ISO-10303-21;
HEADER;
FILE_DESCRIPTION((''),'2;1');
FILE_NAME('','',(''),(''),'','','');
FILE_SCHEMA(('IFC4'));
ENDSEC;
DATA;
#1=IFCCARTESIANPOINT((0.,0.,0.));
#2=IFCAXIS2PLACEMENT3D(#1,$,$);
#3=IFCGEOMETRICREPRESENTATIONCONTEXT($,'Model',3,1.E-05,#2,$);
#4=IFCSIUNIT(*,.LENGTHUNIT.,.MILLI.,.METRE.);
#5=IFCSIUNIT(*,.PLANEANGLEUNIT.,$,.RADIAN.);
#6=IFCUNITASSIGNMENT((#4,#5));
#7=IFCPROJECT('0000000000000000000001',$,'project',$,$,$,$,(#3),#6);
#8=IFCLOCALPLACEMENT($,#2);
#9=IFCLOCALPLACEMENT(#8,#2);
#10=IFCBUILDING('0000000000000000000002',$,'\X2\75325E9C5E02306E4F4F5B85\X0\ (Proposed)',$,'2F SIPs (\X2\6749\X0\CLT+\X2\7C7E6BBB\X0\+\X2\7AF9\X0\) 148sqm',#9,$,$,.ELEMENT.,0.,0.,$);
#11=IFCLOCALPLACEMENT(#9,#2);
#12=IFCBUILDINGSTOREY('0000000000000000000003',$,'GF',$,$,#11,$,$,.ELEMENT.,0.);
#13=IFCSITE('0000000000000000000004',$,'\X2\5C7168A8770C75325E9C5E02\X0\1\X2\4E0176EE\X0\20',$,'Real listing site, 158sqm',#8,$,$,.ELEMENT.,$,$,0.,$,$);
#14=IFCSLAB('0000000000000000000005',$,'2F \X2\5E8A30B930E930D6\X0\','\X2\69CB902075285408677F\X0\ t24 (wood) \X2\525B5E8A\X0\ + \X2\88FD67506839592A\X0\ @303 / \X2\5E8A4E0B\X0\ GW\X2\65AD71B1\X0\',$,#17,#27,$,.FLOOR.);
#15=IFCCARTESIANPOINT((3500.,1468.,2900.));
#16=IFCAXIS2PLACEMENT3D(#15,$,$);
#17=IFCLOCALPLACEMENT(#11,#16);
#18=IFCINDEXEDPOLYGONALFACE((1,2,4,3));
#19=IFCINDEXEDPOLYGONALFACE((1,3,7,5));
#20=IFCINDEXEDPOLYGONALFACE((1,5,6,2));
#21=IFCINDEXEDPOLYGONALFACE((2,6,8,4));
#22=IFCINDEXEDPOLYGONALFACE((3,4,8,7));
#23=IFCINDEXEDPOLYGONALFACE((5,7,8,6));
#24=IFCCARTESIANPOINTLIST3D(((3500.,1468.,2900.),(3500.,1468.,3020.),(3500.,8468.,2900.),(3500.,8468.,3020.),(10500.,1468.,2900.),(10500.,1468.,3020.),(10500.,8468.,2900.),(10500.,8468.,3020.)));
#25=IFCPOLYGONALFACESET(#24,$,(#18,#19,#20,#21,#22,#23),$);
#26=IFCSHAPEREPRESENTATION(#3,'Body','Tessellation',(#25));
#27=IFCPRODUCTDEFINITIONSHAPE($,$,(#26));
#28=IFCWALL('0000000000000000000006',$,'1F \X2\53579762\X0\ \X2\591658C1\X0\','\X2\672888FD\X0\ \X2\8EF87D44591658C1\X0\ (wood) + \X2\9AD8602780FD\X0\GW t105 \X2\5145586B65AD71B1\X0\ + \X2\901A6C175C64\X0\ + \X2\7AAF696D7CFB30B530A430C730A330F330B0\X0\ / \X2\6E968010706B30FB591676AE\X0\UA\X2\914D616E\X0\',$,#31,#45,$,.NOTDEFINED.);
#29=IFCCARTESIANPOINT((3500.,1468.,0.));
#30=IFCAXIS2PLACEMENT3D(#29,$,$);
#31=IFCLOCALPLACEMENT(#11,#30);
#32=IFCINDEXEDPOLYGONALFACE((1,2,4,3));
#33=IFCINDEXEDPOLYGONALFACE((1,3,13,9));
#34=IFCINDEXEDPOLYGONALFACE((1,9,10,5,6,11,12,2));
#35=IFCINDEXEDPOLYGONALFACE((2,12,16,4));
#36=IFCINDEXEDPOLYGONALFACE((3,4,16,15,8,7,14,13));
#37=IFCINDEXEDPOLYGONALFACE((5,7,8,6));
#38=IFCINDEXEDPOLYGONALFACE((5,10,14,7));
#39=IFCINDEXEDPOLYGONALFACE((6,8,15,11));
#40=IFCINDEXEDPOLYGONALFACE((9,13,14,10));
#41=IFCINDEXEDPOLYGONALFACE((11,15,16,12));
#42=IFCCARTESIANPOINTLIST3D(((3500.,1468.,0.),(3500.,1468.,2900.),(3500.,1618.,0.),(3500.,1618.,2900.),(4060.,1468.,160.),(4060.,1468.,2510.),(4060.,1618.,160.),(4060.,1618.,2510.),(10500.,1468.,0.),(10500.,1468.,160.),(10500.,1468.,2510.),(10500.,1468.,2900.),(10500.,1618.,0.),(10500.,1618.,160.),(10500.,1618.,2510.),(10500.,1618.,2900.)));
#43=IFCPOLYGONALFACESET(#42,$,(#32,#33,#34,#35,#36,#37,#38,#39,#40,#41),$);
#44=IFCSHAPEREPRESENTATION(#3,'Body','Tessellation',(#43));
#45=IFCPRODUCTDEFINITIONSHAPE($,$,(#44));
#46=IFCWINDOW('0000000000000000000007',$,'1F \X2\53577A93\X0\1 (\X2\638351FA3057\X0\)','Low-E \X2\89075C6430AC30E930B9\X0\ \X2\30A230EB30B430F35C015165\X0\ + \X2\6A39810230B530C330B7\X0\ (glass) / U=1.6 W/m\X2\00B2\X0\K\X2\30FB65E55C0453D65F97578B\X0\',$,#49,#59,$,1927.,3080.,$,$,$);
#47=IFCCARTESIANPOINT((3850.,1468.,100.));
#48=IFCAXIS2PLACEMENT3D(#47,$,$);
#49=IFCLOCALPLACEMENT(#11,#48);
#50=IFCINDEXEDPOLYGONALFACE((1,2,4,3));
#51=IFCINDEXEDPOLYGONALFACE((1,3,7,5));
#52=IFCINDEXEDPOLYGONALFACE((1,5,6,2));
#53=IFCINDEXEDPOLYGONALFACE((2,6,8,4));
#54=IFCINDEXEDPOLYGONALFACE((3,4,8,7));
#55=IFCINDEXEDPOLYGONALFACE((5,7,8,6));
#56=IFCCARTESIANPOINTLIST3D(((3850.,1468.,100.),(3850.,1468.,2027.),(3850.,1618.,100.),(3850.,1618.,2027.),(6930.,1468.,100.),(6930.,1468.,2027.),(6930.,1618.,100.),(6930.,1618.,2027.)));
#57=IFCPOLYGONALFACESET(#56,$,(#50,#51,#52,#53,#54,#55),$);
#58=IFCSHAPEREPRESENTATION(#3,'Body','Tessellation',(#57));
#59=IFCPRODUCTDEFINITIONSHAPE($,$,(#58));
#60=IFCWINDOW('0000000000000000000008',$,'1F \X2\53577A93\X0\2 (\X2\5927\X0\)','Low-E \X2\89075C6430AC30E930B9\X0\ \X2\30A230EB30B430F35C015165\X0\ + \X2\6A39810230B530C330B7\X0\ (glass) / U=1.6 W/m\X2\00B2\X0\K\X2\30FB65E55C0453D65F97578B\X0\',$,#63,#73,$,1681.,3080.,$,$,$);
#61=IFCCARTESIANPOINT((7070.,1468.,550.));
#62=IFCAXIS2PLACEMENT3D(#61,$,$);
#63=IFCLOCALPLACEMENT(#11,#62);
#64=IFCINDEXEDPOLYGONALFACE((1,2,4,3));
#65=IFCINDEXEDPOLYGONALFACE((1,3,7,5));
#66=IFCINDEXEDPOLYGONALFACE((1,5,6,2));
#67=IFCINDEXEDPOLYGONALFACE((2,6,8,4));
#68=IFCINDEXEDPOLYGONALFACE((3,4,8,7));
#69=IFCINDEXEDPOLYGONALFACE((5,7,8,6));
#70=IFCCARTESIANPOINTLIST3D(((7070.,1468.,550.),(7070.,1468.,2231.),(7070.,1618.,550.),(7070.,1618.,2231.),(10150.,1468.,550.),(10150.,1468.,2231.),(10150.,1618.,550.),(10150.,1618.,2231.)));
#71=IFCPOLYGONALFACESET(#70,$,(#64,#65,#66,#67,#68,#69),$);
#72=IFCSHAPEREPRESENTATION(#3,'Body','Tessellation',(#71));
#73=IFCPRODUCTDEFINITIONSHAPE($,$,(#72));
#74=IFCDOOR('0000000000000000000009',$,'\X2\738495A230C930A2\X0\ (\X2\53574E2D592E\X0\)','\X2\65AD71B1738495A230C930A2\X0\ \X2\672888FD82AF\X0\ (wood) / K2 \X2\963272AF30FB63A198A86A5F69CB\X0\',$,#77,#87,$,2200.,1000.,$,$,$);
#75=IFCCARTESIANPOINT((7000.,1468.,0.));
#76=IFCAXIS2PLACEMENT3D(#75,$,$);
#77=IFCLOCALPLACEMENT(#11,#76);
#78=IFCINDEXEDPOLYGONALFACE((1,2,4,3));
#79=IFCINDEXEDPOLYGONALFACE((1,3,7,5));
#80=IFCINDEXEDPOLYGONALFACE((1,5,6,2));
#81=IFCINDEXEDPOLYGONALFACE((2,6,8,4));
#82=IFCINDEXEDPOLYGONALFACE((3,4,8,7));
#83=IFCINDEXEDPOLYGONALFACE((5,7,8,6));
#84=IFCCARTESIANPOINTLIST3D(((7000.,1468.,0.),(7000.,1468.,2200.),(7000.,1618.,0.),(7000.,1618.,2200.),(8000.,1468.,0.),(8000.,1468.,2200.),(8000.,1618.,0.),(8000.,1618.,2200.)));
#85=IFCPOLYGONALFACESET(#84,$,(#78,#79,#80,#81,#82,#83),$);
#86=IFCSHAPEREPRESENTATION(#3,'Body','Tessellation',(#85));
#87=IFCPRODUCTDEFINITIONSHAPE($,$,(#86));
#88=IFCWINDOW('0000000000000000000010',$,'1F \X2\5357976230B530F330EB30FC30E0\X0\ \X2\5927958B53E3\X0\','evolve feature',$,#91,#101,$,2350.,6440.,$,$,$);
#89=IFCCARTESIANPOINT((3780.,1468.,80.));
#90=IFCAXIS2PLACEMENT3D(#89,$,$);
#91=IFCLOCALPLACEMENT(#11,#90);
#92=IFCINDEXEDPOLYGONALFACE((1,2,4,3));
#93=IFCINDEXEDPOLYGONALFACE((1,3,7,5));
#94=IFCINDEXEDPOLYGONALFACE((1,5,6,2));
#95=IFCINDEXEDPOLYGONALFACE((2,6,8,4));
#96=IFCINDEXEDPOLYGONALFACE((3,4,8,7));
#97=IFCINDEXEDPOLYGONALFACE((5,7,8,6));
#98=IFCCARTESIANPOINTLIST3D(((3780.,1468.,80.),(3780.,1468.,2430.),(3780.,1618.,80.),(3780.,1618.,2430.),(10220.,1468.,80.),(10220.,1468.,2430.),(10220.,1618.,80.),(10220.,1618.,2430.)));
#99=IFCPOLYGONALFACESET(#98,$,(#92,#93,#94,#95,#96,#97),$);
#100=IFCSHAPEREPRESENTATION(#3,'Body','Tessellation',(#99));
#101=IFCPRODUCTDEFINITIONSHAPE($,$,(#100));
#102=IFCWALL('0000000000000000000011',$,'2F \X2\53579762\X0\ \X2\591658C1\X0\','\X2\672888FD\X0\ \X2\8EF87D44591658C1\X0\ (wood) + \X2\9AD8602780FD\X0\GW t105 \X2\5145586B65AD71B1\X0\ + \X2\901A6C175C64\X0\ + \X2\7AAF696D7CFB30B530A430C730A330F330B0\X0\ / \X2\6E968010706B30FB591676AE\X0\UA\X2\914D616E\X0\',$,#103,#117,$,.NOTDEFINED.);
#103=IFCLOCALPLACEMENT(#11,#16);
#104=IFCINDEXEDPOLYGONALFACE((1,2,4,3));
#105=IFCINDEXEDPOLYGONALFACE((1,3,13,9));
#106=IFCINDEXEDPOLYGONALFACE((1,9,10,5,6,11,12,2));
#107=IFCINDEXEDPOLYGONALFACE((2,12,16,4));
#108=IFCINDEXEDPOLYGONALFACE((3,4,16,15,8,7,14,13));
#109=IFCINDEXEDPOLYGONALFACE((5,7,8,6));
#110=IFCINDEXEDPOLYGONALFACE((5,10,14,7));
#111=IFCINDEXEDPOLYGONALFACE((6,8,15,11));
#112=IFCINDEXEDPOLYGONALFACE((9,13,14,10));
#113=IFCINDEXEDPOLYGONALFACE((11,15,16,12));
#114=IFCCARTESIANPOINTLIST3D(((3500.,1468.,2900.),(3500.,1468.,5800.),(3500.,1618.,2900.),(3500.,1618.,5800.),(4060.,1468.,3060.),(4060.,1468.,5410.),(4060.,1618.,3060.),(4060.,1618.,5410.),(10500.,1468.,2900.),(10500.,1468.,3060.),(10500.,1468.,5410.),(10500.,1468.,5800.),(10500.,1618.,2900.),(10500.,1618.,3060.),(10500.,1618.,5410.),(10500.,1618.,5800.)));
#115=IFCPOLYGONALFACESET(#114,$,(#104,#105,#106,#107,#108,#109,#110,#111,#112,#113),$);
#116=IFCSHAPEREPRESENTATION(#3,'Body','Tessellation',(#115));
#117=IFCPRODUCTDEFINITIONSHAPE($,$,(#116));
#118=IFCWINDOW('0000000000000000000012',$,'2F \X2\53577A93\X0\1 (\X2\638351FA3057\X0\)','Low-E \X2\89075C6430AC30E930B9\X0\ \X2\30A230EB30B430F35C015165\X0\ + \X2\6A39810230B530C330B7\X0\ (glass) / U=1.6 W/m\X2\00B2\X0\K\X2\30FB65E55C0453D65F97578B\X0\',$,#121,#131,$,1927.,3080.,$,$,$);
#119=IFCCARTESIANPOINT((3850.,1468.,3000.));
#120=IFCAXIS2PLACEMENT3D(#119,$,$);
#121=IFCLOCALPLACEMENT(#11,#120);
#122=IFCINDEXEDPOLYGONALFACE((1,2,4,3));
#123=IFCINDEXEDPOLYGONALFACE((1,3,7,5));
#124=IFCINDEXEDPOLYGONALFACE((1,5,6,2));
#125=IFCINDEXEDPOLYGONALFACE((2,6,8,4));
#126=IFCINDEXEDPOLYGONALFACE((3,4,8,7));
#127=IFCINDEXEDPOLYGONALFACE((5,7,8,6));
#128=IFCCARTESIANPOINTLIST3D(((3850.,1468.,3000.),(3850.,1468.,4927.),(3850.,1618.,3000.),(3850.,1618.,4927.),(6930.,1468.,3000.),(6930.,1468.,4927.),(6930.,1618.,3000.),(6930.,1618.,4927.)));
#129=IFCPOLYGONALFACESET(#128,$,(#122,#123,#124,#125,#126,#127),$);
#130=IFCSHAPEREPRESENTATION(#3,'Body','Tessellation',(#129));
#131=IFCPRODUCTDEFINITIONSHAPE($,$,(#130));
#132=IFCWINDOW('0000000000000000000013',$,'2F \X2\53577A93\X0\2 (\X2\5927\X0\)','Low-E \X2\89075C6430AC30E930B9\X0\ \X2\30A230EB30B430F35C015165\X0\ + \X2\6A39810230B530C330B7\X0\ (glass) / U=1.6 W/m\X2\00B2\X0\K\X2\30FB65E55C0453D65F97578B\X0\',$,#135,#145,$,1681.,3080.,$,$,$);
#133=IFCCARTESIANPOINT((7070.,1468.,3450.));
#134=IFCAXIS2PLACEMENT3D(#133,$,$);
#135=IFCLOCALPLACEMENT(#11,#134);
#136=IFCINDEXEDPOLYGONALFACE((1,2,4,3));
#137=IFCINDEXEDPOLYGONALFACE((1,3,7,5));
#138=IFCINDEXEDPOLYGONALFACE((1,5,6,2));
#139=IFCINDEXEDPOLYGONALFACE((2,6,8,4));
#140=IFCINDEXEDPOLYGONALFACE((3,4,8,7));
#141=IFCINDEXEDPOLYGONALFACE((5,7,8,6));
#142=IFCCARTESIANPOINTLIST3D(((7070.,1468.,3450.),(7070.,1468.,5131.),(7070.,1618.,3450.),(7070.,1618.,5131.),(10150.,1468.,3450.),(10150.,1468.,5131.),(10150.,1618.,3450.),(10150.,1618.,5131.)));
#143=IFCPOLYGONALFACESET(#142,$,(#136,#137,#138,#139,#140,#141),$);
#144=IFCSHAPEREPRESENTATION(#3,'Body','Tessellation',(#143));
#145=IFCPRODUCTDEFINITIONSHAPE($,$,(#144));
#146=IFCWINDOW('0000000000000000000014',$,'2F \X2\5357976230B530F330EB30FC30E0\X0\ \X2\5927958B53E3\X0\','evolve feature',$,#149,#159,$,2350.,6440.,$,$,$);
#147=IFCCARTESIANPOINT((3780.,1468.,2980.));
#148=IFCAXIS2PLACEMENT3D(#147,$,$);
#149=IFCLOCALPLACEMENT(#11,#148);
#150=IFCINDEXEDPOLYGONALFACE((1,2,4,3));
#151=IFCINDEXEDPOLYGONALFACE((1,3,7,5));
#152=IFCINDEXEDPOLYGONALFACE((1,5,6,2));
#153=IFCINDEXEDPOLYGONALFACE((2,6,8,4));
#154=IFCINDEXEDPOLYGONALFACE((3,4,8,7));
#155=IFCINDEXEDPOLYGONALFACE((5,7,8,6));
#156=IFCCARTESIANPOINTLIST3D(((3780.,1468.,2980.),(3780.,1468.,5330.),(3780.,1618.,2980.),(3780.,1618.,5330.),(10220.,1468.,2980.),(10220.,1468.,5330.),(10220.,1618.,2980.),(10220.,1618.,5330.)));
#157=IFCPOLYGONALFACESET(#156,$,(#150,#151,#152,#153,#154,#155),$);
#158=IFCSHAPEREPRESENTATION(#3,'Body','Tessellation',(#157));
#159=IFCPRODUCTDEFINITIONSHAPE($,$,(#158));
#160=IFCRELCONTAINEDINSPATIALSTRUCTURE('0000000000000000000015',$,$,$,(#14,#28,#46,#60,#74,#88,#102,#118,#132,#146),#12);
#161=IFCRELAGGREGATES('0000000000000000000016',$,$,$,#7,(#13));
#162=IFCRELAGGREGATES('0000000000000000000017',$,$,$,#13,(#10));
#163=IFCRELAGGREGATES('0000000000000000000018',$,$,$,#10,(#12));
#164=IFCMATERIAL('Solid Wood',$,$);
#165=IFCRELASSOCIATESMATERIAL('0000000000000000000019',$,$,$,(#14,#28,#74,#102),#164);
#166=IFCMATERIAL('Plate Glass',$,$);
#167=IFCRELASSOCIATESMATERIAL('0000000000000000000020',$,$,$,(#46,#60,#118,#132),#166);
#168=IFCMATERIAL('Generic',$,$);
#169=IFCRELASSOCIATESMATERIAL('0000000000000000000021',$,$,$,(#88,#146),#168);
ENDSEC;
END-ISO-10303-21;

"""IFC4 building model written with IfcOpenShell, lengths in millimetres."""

from ifc_helpers import new_model, si_unit, frame, frame_2d, origin, place, context, project, spatial, rectangle, extrude, material, element, fill, save


model = new_model("IFC4")

# Units and contexts
model_context = context("Model", 3, precision=1e-05, world=origin())
ifc_project = project(units=[si_unit("LENGTHUNIT", "METRE", prefix="MILLI"), si_unit("PLANEANGLEUNIT", "RADIAN")], contexts=[model_context])

# Site, building, storey
site_placement = place(None, origin())
site = spatial("IfcSite", under=ifc_project, at=site_placement, Name="山梨県甲府市1丁目20", ObjectType="Real listing site, 158sqm", CompositionType="ELEMENT", RefElevation=0.0)
building_placement = place(site_placement, origin())
building = spatial("IfcBuilding", under=site, at=building_placement, Name="甲府市の住宅 (Proposed)", ObjectType="2F SIPs (杉CLT+籾殻+竹) 148sqm", CompositionType="ELEMENT", ElevationOfRefHeight=0.0, ElevationOfTerrain=0.0)
storey_placement = place(building_placement, origin())
storey = spatial("IfcBuildingStorey", under=building, at=storey_placement, Name="GF", CompositionType="ELEMENT", Elevation=0.0)

# Slab
ifc_material_1 = material(Name="Solid Wood")
slab_1_placement = place(storey_placement, frame((3500.0, 1468.0, 2900.0)))
element("IfcSlab", 1, at=slab_1_placement, inside=storey, material=ifc_material_1, Name="2F 床スラブ", Description="構造用合板 t24 (wood) 剛床 + 製材根太 @303 / 床下 GW断熱", PredefinedType="FLOOR", context=model_context, shape_type="SweptSolid", body=[
    extrude(rectangle(XDim=7000.0, YDim=7000.0, at=frame_2d((3500.0, 3500.0))), frame((3500.0, 1468.0, 2900.0)), (0.0, 0.0, 1.0), 120.0),
])
ifc_material_2 = material(Name="Generic")

# Wall, openings, windows, door
wall_1_placement = place(storey_placement, frame((3500.0, 1468.0, 0.0)))
wall_1 = element("IfcWall", 2, at=wall_1_placement, inside=storey, material=ifc_material_1, Name="1F 南面 外壁", Description="木製 軸組外壁 (wood) + 高性能GW t105 充填断熱 + 通気層 + 窯業系サイディング / 準耐火・外皮UA配慮", PredefinedType="NOTDEFINED", context=model_context, shape_type="SweptSolid", body=[
    extrude(rectangle(XDim=7000.0, YDim=150.0, at=frame_2d((3500.0, 75.0))), frame((3500.0, 1468.0, 0.0)), (0.0, 0.0, 1.0), 2900.0),
])
opening_1_placement = place(storey_placement, frame((3850.0, 1468.0, 100.0)))
opening_1 = element("IfcOpeningElement", 3, at=opening_1_placement, cuts=wall_1, PredefinedType="NOTDEFINED", context=model_context, shape_type="SweptSolid", body=[
    extrude(rectangle(XDim=3080.0, YDim=150.0, at=frame_2d((1540.0, 75.0))), frame((3850.0, 1468.0, 100.0)), (0.0, 0.0, 1.0), 1927.0),
])
opening_2_placement = place(storey_placement, frame((7070.0, 1468.0, 550.0)))
opening_2 = element("IfcOpeningElement", 4, at=opening_2_placement, cuts=wall_1, PredefinedType="NOTDEFINED", context=model_context, shape_type="SweptSolid", body=[
    extrude(rectangle(XDim=3080.0, YDim=150.0, at=frame_2d((1540.0, 75.0))), frame((7070.0, 1468.0, 550.0)), (0.0, 0.0, 1.0), 1681.0),
])
opening_3_placement = place(storey_placement, frame((7000.0, 1468.0, 0.0)))
opening_3 = element("IfcOpeningElement", 5, at=opening_3_placement, cuts=wall_1, PredefinedType="NOTDEFINED", context=model_context, shape_type="SweptSolid", body=[
    extrude(rectangle(XDim=1000.0, YDim=150.0, at=frame_2d((500.0, 75.0))), frame((7000.0, 1468.0, 0.0)), (0.0, 0.0, 1.0), 2200.0),
])
opening_4_placement = place(storey_placement, frame((3780.0, 1468.0, 80.0)))
opening_4 = element("IfcOpeningElement", 6, at=opening_4_placement, cuts=wall_1, PredefinedType="NOTDEFINED", context=model_context, shape_type="SweptSolid", body=[
    extrude(rectangle(XDim=6440.0, YDim=150.0, at=frame_2d((3220.0, 75.0))), frame((3780.0, 1468.0, 80.0)), (0.0, 0.0, 1.0), 2350.0),
])
ifc_material_3 = material(Name="Plate Glass")
window_1_placement = place(storey_placement, frame((3850.0, 1468.0, 100.0)))
window_1 = element("IfcWindow", 7, at=window_1_placement, inside=storey, material=ifc_material_3, Name="1F 南窓1 (掃出し)", Description="Low-E 複層ガラス アルゴン封入 + 樹脂サッシ (glass) / U=1.6 W/m²K・日射取得型", OverallHeight=1927.0, OverallWidth=3080.0, context=model_context, shape_type="SweptSolid", body=[
    extrude(rectangle(XDim=3080.0, YDim=150.0, at=frame_2d((1540.0, 75.0))), frame((3850.0, 1468.0, 100.0)), (0.0, 0.0, 1.0), 1927.0),
])
fill(opening_1, window_1)
window_2_placement = place(storey_placement, frame((7070.0, 1468.0, 550.0)))
window_2 = element("IfcWindow", 8, at=window_2_placement, inside=storey, material=ifc_material_3, Name="1F 南窓2 (大)", Description="Low-E 複層ガラス アルゴン封入 + 樹脂サッシ (glass) / U=1.6 W/m²K・日射取得型", OverallHeight=1681.0, OverallWidth=3080.0, context=model_context, shape_type="SweptSolid", body=[
    extrude(rectangle(XDim=3080.0, YDim=150.0, at=frame_2d((1540.0, 75.0))), frame((7070.0, 1468.0, 550.0)), (0.0, 0.0, 1.0), 1681.0),
])
fill(opening_2, window_2)
door_placement = place(storey_placement, frame((7000.0, 1468.0, 0.0)))
door = element("IfcDoor", 9, at=door_placement, inside=storey, material=ifc_material_1, Name="玄関ドア (南中央)", Description="断熱玄関ドア 木製芯 (wood) / K2 防犯・採風機構", OverallHeight=2200.0, OverallWidth=1000.0, context=model_context, shape_type="SweptSolid", body=[
    extrude(rectangle(XDim=1000.0, YDim=150.0, at=frame_2d((500.0, 75.0))), frame((7000.0, 1468.0, 0.0)), (0.0, 0.0, 1.0), 2200.0),
])
fill(opening_3, door)
window_3_placement = place(storey_placement, frame((3780.0, 1468.0, 80.0)))
window_3 = element("IfcWindow", 10, at=window_3_placement, inside=storey, material=ifc_material_2, Name="1F 南面サンルーム 大開口", Description="evolve feature", OverallHeight=2350.0, OverallWidth=6440.0, context=model_context, shape_type="SweptSolid", body=[
    extrude(rectangle(XDim=6440.0, YDim=150.0, at=frame_2d((3220.0, 75.0))), frame((3780.0, 1468.0, 80.0)), (0.0, 0.0, 1.0), 2350.0),
])
fill(opening_4, window_3)

# Wall, openings, windows
wall_2_placement = place(storey_placement, frame((3500.0, 1468.0, 2900.0)))
wall_2 = element("IfcWall", 11, at=wall_2_placement, inside=storey, material=ifc_material_1, Name="2F 南面 外壁", Description="木製 軸組外壁 (wood) + 高性能GW t105 充填断熱 + 通気層 + 窯業系サイディング / 準耐火・外皮UA配慮", PredefinedType="NOTDEFINED", context=model_context, shape_type="SweptSolid", body=[
    extrude(rectangle(XDim=7000.0, YDim=150.0, at=frame_2d((3500.0, 75.0))), frame((3500.0, 1468.0, 2900.0)), (0.0, 0.0, 1.0), 2900.0),
])
opening_5_placement = place(storey_placement, frame((3850.0, 1468.0, 3000.0)))
opening_5 = element("IfcOpeningElement", 12, at=opening_5_placement, cuts=wall_2, PredefinedType="NOTDEFINED", context=model_context, shape_type="SweptSolid", body=[
    extrude(rectangle(XDim=3080.0, YDim=150.0, at=frame_2d((1540.0, 75.0))), frame((3850.0, 1468.0, 3000.0)), (0.0, 0.0, 1.0), 1927.0),
])
opening_6_placement = place(storey_placement, frame((7070.0, 1468.0, 3450.0)))
opening_6 = element("IfcOpeningElement", 13, at=opening_6_placement, cuts=wall_2, PredefinedType="NOTDEFINED", context=model_context, shape_type="SweptSolid", body=[
    extrude(rectangle(XDim=3080.0, YDim=150.0, at=frame_2d((1540.0, 75.0))), frame((7070.0, 1468.0, 3450.0)), (0.0, 0.0, 1.0), 1681.0),
])
opening_7_placement = place(storey_placement, frame((3780.0, 1468.0, 2980.0)))
opening_7 = element("IfcOpeningElement", 14, at=opening_7_placement, cuts=wall_2, PredefinedType="NOTDEFINED", context=model_context, shape_type="SweptSolid", body=[
    extrude(rectangle(XDim=6440.0, YDim=150.0, at=frame_2d((3220.0, 75.0))), frame((3780.0, 1468.0, 2980.0)), (0.0, 0.0, 1.0), 2350.0),
])
window_4_placement = place(storey_placement, frame((3850.0, 1468.0, 3000.0)))
window_4 = element("IfcWindow", 15, at=window_4_placement, inside=storey, material=ifc_material_3, Name="2F 南窓1 (掃出し)", Description="Low-E 複層ガラス アルゴン封入 + 樹脂サッシ (glass) / U=1.6 W/m²K・日射取得型", OverallHeight=1927.0, OverallWidth=3080.0, context=model_context, shape_type="SweptSolid", body=[
    extrude(rectangle(XDim=3080.0, YDim=150.0, at=frame_2d((1540.0, 75.0))), frame((3850.0, 1468.0, 3000.0)), (0.0, 0.0, 1.0), 1927.0),
])
fill(opening_5, window_4)
window_5_placement = place(storey_placement, frame((7070.0, 1468.0, 3450.0)))
window_5 = element("IfcWindow", 16, at=window_5_placement, inside=storey, material=ifc_material_3, Name="2F 南窓2 (大)", Description="Low-E 複層ガラス アルゴン封入 + 樹脂サッシ (glass) / U=1.6 W/m²K・日射取得型", OverallHeight=1681.0, OverallWidth=3080.0, context=model_context, shape_type="SweptSolid", body=[
    extrude(rectangle(XDim=3080.0, YDim=150.0, at=frame_2d((1540.0, 75.0))), frame((7070.0, 1468.0, 3450.0)), (0.0, 0.0, 1.0), 1681.0),
])
fill(opening_6, window_5)
window_6_placement = place(storey_placement, frame((3780.0, 1468.0, 2980.0)))
window_6 = element("IfcWindow", 17, at=window_6_placement, inside=storey, material=ifc_material_2, Name="2F 南面サンルーム 大開口", Description="evolve feature", OverallHeight=2350.0, OverallWidth=6440.0, context=model_context, shape_type="SweptSolid", body=[
    extrude(rectangle(XDim=6440.0, YDim=150.0, at=frame_2d((3220.0, 75.0))), frame((3780.0, 1468.0, 2980.0)), (0.0, 0.0, 1.0), 2350.0),
])
fill(opening_7, window_6)

save(model, "model.ifc")
